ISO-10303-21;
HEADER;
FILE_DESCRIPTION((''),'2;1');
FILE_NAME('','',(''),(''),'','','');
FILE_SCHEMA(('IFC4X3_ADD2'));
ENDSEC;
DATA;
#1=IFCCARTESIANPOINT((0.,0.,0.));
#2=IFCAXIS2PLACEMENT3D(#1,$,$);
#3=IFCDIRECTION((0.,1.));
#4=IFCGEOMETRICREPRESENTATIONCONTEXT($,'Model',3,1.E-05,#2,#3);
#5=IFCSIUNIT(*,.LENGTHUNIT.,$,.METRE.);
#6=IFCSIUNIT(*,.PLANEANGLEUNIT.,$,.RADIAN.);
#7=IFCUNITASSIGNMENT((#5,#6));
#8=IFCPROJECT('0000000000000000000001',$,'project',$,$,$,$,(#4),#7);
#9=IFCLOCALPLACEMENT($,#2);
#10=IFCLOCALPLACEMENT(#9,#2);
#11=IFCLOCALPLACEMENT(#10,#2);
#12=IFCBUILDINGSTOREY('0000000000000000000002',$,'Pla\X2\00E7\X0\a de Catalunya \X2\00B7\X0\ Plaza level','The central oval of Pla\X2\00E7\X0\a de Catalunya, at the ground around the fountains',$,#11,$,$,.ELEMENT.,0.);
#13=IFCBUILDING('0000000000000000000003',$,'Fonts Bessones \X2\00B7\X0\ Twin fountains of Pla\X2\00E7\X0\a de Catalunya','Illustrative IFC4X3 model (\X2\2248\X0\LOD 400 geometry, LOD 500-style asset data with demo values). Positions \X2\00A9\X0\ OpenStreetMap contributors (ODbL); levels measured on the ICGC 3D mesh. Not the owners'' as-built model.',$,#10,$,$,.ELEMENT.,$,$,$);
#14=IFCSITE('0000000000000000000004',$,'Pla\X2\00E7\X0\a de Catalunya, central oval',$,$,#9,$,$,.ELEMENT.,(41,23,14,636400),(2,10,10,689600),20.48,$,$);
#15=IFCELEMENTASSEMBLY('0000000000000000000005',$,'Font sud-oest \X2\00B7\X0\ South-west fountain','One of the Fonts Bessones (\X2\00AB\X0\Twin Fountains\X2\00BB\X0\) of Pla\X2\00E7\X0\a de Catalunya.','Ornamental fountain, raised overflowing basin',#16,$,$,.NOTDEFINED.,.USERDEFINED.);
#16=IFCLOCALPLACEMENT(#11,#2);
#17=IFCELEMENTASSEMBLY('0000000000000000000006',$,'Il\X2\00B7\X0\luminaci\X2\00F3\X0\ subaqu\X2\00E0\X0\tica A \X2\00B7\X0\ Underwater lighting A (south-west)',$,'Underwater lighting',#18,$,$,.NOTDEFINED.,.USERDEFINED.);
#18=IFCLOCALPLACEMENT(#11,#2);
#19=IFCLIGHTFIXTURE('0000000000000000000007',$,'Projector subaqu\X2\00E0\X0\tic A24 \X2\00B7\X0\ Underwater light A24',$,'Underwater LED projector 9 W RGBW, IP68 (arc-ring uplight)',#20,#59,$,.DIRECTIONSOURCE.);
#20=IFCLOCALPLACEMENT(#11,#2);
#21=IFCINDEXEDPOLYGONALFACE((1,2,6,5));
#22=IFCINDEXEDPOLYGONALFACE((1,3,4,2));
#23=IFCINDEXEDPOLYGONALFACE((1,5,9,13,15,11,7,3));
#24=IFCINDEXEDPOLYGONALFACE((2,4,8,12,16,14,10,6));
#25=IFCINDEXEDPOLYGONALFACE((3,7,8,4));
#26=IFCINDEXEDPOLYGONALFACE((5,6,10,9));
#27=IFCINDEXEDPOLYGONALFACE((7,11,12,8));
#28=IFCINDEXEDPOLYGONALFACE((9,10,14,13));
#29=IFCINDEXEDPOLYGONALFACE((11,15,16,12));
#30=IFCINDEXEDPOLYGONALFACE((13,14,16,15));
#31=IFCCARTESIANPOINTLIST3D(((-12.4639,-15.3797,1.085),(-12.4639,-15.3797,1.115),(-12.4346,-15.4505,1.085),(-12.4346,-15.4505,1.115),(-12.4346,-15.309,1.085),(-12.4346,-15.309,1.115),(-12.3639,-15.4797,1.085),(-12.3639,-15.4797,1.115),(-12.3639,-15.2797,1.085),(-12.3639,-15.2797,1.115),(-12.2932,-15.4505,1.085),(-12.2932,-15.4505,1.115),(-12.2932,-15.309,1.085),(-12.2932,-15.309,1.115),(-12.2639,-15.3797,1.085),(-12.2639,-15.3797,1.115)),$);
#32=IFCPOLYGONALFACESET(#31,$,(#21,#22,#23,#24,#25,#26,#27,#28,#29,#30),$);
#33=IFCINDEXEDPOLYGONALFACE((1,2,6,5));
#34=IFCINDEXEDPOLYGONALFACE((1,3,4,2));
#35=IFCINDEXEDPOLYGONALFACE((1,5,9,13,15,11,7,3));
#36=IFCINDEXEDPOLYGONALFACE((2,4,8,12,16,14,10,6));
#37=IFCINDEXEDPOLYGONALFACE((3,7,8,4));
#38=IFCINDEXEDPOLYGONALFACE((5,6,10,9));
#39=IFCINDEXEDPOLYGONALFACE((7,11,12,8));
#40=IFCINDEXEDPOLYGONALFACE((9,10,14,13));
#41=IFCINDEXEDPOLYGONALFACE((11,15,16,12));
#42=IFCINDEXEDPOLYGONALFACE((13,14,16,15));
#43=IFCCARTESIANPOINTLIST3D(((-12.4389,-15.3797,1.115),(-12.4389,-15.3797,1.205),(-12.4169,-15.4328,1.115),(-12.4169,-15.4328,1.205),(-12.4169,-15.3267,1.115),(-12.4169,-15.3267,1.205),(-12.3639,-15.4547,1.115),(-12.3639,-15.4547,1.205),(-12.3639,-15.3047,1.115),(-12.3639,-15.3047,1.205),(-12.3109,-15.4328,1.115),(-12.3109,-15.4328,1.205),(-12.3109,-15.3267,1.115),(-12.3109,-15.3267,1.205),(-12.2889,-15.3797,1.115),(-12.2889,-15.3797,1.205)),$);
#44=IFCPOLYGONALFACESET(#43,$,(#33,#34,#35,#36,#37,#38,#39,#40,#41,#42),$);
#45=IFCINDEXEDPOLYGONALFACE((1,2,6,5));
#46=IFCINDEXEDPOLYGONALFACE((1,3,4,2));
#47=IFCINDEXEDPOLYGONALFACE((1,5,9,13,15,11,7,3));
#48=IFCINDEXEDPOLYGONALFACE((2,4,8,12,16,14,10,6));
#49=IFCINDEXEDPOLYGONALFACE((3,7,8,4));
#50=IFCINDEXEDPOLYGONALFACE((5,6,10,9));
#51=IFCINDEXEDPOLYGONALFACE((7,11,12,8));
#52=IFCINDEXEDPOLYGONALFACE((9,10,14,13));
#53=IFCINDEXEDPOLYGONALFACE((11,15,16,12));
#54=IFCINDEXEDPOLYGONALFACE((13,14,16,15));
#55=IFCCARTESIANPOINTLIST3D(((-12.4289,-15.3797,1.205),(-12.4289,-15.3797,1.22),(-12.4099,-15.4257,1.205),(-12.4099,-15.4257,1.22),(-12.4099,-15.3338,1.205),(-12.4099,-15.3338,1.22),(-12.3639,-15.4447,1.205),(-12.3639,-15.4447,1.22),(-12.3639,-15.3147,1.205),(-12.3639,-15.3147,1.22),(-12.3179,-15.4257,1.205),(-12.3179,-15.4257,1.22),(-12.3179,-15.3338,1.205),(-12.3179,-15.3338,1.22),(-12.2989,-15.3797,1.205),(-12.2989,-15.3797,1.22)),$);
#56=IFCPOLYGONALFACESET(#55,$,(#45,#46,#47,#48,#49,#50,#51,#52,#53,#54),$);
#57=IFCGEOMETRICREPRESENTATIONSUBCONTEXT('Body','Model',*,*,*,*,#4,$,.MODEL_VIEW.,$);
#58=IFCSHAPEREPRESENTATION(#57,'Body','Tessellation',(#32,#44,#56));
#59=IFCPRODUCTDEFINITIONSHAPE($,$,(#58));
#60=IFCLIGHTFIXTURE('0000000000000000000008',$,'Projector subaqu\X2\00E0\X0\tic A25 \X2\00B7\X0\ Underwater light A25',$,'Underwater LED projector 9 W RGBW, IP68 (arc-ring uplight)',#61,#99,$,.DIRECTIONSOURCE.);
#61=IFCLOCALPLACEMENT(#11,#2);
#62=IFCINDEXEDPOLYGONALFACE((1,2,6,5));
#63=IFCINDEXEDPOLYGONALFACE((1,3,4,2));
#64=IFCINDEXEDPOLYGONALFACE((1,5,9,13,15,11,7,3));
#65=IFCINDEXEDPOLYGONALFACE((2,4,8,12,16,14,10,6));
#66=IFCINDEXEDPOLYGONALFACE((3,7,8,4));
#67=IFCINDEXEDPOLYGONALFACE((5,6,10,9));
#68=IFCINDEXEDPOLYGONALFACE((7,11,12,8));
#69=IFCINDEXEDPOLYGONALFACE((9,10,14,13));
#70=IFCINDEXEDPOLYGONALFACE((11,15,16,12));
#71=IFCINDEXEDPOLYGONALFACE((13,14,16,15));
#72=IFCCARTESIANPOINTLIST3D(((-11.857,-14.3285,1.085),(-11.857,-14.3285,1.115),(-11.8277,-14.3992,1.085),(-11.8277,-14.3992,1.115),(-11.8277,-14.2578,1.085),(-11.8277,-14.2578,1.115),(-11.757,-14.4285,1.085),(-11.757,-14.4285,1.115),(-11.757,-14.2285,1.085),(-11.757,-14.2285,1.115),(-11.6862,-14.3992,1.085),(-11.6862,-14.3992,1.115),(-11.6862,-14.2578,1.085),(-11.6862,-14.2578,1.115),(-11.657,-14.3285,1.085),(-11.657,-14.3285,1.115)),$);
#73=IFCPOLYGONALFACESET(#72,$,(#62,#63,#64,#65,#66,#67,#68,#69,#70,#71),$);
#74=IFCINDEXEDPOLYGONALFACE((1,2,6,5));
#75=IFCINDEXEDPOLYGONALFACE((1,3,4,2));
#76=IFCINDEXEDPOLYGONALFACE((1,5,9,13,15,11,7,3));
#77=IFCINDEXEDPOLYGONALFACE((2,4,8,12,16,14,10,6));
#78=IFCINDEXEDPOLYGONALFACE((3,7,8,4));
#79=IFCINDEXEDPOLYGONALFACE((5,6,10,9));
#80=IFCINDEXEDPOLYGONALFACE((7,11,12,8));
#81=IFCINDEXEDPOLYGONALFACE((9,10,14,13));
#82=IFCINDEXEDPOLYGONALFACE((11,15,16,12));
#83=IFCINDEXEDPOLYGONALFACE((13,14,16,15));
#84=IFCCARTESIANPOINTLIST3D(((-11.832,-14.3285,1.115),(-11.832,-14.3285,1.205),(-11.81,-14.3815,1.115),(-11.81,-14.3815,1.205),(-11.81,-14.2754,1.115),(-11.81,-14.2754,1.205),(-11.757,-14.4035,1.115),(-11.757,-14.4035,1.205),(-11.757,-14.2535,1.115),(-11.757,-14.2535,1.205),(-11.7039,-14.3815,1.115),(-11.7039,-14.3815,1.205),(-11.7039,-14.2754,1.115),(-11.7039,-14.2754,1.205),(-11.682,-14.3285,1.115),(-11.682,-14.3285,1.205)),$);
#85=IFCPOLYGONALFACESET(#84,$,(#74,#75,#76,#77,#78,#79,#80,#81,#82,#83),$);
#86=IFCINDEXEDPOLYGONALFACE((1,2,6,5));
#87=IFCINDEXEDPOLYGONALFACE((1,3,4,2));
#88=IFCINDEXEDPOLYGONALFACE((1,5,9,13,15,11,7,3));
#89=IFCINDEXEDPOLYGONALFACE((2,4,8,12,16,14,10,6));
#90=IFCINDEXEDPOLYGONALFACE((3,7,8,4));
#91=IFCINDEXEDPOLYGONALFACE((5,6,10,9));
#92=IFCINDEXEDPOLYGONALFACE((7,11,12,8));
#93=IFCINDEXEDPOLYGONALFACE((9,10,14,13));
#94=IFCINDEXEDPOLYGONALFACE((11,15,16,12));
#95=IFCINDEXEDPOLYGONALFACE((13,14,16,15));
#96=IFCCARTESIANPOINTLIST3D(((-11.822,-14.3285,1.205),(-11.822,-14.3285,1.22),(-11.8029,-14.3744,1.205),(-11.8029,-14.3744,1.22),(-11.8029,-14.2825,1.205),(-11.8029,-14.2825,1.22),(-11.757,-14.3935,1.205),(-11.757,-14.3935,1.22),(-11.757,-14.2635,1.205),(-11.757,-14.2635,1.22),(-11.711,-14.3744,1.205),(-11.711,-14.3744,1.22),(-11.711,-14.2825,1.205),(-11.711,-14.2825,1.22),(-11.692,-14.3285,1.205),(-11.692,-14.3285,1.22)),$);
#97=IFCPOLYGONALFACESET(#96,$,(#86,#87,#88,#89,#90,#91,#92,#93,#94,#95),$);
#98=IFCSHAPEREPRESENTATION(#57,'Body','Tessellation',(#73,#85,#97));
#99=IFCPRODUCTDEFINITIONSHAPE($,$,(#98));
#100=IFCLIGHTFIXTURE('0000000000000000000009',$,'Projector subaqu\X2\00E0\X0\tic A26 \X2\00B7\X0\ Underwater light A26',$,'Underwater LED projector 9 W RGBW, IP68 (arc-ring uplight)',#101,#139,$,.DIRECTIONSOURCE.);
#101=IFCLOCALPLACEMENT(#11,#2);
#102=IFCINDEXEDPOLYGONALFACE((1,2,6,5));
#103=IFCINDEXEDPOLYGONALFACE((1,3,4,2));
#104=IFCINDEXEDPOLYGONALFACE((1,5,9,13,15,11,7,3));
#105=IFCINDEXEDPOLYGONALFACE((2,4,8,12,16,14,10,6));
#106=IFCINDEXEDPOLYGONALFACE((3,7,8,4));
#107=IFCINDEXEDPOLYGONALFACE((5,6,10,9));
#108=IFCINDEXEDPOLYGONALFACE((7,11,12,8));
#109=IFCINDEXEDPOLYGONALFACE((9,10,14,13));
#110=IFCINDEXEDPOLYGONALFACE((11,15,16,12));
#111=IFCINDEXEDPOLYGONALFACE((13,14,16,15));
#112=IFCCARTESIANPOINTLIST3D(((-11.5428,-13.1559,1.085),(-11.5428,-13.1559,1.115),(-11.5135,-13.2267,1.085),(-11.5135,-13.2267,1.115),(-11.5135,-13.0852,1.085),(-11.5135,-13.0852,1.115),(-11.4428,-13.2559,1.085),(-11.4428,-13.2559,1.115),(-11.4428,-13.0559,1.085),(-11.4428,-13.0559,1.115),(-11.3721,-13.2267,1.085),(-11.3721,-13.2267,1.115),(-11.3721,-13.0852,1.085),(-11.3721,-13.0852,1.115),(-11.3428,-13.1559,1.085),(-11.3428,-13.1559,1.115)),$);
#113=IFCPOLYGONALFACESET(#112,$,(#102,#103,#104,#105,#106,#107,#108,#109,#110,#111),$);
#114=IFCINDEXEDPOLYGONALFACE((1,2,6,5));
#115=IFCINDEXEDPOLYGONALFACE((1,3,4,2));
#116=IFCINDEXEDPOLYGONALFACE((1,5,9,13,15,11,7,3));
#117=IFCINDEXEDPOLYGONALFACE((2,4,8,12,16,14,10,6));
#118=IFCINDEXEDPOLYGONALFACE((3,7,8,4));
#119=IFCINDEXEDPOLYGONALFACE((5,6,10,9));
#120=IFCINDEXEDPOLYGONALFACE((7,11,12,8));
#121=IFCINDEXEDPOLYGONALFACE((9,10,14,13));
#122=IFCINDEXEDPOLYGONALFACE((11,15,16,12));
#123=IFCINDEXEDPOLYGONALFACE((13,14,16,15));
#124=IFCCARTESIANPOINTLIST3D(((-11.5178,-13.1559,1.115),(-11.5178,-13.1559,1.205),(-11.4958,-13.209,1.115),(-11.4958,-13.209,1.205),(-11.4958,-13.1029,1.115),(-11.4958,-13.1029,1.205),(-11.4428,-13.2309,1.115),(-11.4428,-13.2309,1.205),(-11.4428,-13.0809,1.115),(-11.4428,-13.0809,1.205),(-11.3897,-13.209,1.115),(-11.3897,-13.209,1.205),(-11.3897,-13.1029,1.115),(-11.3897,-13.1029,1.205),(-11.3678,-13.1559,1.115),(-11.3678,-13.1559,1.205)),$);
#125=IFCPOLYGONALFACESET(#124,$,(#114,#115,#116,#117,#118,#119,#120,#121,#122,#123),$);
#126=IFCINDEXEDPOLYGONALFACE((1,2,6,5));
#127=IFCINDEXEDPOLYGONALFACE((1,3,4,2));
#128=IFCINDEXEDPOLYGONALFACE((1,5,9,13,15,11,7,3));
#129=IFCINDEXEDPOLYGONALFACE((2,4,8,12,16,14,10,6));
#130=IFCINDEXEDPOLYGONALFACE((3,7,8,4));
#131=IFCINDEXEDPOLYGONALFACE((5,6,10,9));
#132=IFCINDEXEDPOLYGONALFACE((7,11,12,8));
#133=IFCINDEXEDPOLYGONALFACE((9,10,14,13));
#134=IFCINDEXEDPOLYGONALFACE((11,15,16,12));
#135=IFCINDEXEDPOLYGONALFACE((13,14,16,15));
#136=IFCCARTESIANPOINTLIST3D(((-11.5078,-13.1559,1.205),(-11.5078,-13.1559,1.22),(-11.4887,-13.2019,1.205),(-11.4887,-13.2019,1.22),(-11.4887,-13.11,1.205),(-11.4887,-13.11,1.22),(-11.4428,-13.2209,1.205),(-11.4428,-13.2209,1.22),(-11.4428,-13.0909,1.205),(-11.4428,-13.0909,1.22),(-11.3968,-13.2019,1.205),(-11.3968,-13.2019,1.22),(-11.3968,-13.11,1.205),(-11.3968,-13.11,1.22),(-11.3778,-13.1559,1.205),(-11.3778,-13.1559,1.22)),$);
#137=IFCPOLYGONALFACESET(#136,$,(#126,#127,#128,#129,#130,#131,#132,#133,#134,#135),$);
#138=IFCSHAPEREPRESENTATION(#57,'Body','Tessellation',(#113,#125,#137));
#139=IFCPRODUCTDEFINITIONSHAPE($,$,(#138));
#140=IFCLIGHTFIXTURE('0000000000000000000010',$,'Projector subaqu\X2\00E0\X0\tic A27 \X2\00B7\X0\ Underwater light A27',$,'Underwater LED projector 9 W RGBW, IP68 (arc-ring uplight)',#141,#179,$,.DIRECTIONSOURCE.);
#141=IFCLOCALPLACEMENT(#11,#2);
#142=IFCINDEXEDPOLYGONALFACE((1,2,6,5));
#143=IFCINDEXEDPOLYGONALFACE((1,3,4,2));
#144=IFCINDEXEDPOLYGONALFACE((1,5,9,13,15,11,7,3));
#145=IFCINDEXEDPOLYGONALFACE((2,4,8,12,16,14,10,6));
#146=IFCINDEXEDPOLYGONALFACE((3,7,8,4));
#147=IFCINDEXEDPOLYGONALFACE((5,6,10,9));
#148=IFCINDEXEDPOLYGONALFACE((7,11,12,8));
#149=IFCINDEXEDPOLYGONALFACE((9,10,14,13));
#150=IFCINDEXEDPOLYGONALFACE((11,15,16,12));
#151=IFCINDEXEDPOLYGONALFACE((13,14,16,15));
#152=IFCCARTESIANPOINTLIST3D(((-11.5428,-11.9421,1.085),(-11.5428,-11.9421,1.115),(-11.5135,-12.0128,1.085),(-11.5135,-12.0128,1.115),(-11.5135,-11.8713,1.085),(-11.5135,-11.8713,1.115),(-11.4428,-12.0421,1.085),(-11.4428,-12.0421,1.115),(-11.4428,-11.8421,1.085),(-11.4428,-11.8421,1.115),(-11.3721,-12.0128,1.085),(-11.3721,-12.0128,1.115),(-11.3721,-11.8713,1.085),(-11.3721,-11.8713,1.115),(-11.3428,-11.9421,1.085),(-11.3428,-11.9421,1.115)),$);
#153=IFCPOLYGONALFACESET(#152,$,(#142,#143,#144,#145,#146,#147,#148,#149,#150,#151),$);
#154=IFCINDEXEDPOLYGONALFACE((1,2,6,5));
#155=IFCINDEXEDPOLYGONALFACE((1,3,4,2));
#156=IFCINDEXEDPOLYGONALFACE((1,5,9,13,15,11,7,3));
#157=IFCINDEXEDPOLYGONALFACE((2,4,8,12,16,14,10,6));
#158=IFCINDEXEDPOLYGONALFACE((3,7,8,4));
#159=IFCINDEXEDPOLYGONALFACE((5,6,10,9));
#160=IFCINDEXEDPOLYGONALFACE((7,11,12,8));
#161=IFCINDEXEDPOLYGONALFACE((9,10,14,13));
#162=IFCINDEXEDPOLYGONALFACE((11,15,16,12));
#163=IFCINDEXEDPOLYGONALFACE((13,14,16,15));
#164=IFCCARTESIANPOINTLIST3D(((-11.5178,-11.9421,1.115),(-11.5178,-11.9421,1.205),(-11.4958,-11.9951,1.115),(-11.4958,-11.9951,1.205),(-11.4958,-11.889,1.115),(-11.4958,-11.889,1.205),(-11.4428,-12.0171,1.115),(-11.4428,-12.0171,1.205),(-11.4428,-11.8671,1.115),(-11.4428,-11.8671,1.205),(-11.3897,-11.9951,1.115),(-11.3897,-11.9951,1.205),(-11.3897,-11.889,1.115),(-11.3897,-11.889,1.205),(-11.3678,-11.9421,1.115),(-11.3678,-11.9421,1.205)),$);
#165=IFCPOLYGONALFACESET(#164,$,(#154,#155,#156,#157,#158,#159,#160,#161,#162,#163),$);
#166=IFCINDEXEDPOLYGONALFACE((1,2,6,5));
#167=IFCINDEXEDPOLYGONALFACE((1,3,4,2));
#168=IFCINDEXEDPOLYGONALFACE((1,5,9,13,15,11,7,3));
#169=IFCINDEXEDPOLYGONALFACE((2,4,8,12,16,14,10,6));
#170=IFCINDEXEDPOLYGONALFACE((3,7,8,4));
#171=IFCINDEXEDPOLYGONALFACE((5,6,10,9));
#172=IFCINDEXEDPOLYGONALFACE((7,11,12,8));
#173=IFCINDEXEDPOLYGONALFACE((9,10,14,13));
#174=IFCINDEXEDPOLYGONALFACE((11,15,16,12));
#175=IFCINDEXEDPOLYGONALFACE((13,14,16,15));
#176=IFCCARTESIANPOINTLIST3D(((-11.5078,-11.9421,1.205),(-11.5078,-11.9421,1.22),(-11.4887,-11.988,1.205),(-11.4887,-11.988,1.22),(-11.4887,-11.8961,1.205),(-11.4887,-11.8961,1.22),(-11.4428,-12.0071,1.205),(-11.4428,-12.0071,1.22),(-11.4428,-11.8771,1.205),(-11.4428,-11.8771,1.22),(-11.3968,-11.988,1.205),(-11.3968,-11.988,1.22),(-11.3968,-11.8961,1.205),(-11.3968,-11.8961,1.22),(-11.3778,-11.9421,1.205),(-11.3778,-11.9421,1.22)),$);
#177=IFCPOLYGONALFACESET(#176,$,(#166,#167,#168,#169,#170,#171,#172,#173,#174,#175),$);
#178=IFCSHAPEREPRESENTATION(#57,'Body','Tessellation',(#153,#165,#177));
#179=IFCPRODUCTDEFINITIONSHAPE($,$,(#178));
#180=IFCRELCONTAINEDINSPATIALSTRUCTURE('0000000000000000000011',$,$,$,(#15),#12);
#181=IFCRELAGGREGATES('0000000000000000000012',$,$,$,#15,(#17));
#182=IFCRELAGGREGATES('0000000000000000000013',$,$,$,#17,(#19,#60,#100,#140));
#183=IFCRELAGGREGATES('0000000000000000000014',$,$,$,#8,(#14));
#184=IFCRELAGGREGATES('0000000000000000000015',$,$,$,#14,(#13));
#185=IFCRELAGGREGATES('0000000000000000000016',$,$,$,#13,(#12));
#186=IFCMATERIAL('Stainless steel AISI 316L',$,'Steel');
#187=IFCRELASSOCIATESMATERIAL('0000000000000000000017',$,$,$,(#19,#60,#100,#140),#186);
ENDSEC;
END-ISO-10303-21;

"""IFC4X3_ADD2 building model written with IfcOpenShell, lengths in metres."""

from ifc_helpers import new_model, si_unit, direction, frame, origin, place, context, subcontext, project, spatial, polyline, outline, extrude, material, element, aggregate, save


model = new_model("IFC4X3_ADD2")

# Units and contexts
model_context = context("Model", 3, precision=1e-05, world=origin(), true_north=direction((0.0, 1.0)))
body_context = subcontext(model_context, "Body", "Model", "MODEL_VIEW")
ifc_project = project(units=[si_unit("LENGTHUNIT", "METRE"), si_unit("PLANEANGLEUNIT", "RADIAN")], contexts=[model_context])

# Site, building, storey
site_placement = place(None, origin())
site = spatial("IfcSite", under=ifc_project, at=site_placement, Name="Plaça de Catalunya, central oval", CompositionType="ELEMENT", RefLatitude=(41, 23, 14, 636400), RefLongitude=(2, 10, 10, 689600), RefElevation=20.48)
building_placement = place(site_placement, origin())
building = spatial("IfcBuilding", under=site, at=building_placement, Name="Fonts Bessones · Twin fountains of Plaça de Catalunya", Description="Illustrative IFC4X3 model (≈LOD 400 geometry, LOD 500-style asset data with demo values). Positions © OpenStreetMap contributors (ODbL); levels measured on the ICGC 3D mesh. Not the owners' as-built model.", CompositionType="ELEMENT")
storey_placement = place(building_placement, origin())
storey = spatial("IfcBuildingStorey", under=building, at=storey_placement, Name="Plaça de Catalunya · Plaza level", Description="The central oval of Plaça de Catalunya, at the ground around the fountains", CompositionType="ELEMENT", Elevation=0.0)

# Element assemblies, light fixtures
assembly_1_placement = place(building_placement, origin())
assembly_1 = element("IfcElementAssembly", 1, at=assembly_1_placement, inside=storey, Name="Font sud-oest · South-west fountain", Description="One of the Fonts Bessones («Twin Fountains») of Plaça de Catalunya.", ObjectType="Ornamental fountain, raised overflowing basin", AssemblyPlace="NOTDEFINED", PredefinedType="USERDEFINED")
assembly_2_placement = place(building_placement, origin())
assembly_2 = element("IfcElementAssembly", 2, at=assembly_2_placement, Name="Il·luminació subaquàtica A · Underwater lighting A (south-west)", ObjectType="Underwater lighting", AssemblyPlace="NOTDEFINED", PredefinedType="USERDEFINED")
aggregate(assembly_1, [assembly_2])
ifc_material_1 = material(Name="Stainless steel AISI 316L", Category="Steel")
light_fixture_1_placement = place(building_placement, origin())
light_fixture_1 = element("IfcLightFixture", 3, at=light_fixture_1_placement, material=ifc_material_1, Name="Projector subaquàtic A24 · Underwater light A24", ObjectType="Underwater LED projector 9 W RGBW, IP68 (arc-ring uplight)", PredefinedType="DIRECTIONSOURCE", context=body_context, shape_type="SweptSolid", body=[
    extrude(outline(polyline([(-12.2639, -15.3797), (-12.2932, -15.309), (-12.3639, -15.2797), (-12.4346, -15.309), (-12.4639, -15.3797), (-12.4346, -15.4505), (-12.3639, -15.4797), (-12.2932, -15.4505), (-12.2639, -15.3797)])), frame((0.0, 0.0, 1.085)), (0.0, 0.0, 1.0), 0.03),
    extrude(outline(polyline([(-12.2889, -15.3797), (-12.3109, -15.3267), (-12.3639, -15.3047), (-12.4169, -15.3267), (-12.4389, -15.3797), (-12.4169, -15.4328), (-12.3639, -15.4547), (-12.3109, -15.4328), (-12.2889, -15.3797)])), frame((0.0, 0.0, 1.115)), (0.0, 0.0, 1.0), 0.09),
    extrude(outline(polyline([(-12.2989, -15.3797), (-12.3179, -15.3338), (-12.3639, -15.3147), (-12.4099, -15.3338), (-12.4289, -15.3797), (-12.4099, -15.4257), (-12.3639, -15.4447), (-12.3179, -15.4257), (-12.2989, -15.3797)])), frame((0.0, 0.0, 1.205)), (0.0, 0.0, 1.0), 0.015),
])
light_fixture_2_placement = place(building_placement, origin())
light_fixture_2 = element("IfcLightFixture", 4, at=light_fixture_2_placement, material=ifc_material_1, Name="Projector subaquàtic A25 · Underwater light A25", ObjectType="Underwater LED projector 9 W RGBW, IP68 (arc-ring uplight)", PredefinedType="DIRECTIONSOURCE", context=body_context, shape_type="SweptSolid", body=[
    extrude(outline(polyline([(-11.657, -14.3285), (-11.6862, -14.2578), (-11.757, -14.2285), (-11.8277, -14.2578), (-11.857, -14.3285), (-11.8277, -14.3992), (-11.757, -14.4285), (-11.6862, -14.3992), (-11.657, -14.3285)])), frame((0.0, 0.0, 1.085)), (0.0, 0.0, 1.0), 0.03),
    extrude(outline(polyline([(-11.682, -14.3285), (-11.7039, -14.2754), (-11.757, -14.2535), (-11.81, -14.2754), (-11.832, -14.3285), (-11.81, -14.3815), (-11.757, -14.4035), (-11.7039, -14.3815), (-11.682, -14.3285)])), frame((0.0, 0.0, 1.115)), (0.0, 0.0, 1.0), 0.09),
    extrude(outline(polyline([(-11.692, -14.3285), (-11.711, -14.2825), (-11.757, -14.2635), (-11.8029, -14.2825), (-11.822, -14.3285), (-11.8029, -14.3744), (-11.757, -14.3935), (-11.711, -14.3744), (-11.692, -14.3285)])), frame((0.0, 0.0, 1.205)), (0.0, 0.0, 1.0), 0.015),
])
light_fixture_3_placement = place(building_placement, origin())
light_fixture_3 = element("IfcLightFixture", 5, at=light_fixture_3_placement, material=ifc_material_1, Name="Projector subaquàtic A26 · Underwater light A26", ObjectType="Underwater LED projector 9 W RGBW, IP68 (arc-ring uplight)", PredefinedType="DIRECTIONSOURCE", context=body_context, shape_type="SweptSolid", body=[
    extrude(outline(polyline([(-11.3428, -13.1559), (-11.3721, -13.0852), (-11.4428, -13.0559), (-11.5135, -13.0852), (-11.5428, -13.1559), (-11.5135, -13.2267), (-11.4428, -13.2559), (-11.3721, -13.2267), (-11.3428, -13.1559)])), frame((0.0, 0.0, 1.085)), (0.0, 0.0, 1.0), 0.03),
    extrude(outline(polyline([(-11.3678, -13.1559), (-11.3897, -13.1029), (-11.4428, -13.0809), (-11.4958, -13.1029), (-11.5178, -13.1559), (-11.4958, -13.209), (-11.4428, -13.2309), (-11.3897, -13.209), (-11.3678, -13.1559)])), frame((0.0, 0.0, 1.115)), (0.0, 0.0, 1.0), 0.09),
    extrude(outline(polyline([(-11.3778, -13.1559), (-11.3968, -13.11), (-11.4428, -13.0909), (-11.4887, -13.11), (-11.5078, -13.1559), (-11.4887, -13.2019), (-11.4428, -13.2209), (-11.3968, -13.2019), (-11.3778, -13.1559)])), frame((0.0, 0.0, 1.205)), (0.0, 0.0, 1.0), 0.015),
])
light_fixture_4_placement = place(building_placement, origin())
light_fixture_4 = element("IfcLightFixture", 6, at=light_fixture_4_placement, material=ifc_material_1, Name="Projector subaquàtic A27 · Underwater light A27", ObjectType="Underwater LED projector 9 W RGBW, IP68 (arc-ring uplight)", PredefinedType="DIRECTIONSOURCE", context=body_context, shape_type="SweptSolid", body=[
    extrude(outline(polyline([(-11.3428, -11.9421), (-11.3721, -11.8713), (-11.4428, -11.8421), (-11.5135, -11.8713), (-11.5428, -11.9421), (-11.5135, -12.0128), (-11.4428, -12.0421), (-11.3721, -12.0128), (-11.3428, -11.9421)])), frame((0.0, 0.0, 1.085)), (0.0, 0.0, 1.0), 0.03),
    extrude(outline(polyline([(-11.3678, -11.9421), (-11.3897, -11.889), (-11.4428, -11.8671), (-11.4958, -11.889), (-11.5178, -11.9421), (-11.4958, -11.9951), (-11.4428, -12.0171), (-11.3897, -11.9951), (-11.3678, -11.9421)])), frame((0.0, 0.0, 1.115)), (0.0, 0.0, 1.0), 0.09),
    extrude(outline(polyline([(-11.3778, -11.9421), (-11.3968, -11.8961), (-11.4428, -11.8771), (-11.4887, -11.8961), (-11.5078, -11.9421), (-11.4887, -11.988), (-11.4428, -12.0071), (-11.3968, -11.988), (-11.3778, -11.9421)])), frame((0.0, 0.0, 1.205)), (0.0, 0.0, 1.0), 0.015),
])
aggregate(assembly_2, [light_fixture_1, light_fixture_2, light_fixture_3, light_fixture_4])

save(model, "model.ifc")
